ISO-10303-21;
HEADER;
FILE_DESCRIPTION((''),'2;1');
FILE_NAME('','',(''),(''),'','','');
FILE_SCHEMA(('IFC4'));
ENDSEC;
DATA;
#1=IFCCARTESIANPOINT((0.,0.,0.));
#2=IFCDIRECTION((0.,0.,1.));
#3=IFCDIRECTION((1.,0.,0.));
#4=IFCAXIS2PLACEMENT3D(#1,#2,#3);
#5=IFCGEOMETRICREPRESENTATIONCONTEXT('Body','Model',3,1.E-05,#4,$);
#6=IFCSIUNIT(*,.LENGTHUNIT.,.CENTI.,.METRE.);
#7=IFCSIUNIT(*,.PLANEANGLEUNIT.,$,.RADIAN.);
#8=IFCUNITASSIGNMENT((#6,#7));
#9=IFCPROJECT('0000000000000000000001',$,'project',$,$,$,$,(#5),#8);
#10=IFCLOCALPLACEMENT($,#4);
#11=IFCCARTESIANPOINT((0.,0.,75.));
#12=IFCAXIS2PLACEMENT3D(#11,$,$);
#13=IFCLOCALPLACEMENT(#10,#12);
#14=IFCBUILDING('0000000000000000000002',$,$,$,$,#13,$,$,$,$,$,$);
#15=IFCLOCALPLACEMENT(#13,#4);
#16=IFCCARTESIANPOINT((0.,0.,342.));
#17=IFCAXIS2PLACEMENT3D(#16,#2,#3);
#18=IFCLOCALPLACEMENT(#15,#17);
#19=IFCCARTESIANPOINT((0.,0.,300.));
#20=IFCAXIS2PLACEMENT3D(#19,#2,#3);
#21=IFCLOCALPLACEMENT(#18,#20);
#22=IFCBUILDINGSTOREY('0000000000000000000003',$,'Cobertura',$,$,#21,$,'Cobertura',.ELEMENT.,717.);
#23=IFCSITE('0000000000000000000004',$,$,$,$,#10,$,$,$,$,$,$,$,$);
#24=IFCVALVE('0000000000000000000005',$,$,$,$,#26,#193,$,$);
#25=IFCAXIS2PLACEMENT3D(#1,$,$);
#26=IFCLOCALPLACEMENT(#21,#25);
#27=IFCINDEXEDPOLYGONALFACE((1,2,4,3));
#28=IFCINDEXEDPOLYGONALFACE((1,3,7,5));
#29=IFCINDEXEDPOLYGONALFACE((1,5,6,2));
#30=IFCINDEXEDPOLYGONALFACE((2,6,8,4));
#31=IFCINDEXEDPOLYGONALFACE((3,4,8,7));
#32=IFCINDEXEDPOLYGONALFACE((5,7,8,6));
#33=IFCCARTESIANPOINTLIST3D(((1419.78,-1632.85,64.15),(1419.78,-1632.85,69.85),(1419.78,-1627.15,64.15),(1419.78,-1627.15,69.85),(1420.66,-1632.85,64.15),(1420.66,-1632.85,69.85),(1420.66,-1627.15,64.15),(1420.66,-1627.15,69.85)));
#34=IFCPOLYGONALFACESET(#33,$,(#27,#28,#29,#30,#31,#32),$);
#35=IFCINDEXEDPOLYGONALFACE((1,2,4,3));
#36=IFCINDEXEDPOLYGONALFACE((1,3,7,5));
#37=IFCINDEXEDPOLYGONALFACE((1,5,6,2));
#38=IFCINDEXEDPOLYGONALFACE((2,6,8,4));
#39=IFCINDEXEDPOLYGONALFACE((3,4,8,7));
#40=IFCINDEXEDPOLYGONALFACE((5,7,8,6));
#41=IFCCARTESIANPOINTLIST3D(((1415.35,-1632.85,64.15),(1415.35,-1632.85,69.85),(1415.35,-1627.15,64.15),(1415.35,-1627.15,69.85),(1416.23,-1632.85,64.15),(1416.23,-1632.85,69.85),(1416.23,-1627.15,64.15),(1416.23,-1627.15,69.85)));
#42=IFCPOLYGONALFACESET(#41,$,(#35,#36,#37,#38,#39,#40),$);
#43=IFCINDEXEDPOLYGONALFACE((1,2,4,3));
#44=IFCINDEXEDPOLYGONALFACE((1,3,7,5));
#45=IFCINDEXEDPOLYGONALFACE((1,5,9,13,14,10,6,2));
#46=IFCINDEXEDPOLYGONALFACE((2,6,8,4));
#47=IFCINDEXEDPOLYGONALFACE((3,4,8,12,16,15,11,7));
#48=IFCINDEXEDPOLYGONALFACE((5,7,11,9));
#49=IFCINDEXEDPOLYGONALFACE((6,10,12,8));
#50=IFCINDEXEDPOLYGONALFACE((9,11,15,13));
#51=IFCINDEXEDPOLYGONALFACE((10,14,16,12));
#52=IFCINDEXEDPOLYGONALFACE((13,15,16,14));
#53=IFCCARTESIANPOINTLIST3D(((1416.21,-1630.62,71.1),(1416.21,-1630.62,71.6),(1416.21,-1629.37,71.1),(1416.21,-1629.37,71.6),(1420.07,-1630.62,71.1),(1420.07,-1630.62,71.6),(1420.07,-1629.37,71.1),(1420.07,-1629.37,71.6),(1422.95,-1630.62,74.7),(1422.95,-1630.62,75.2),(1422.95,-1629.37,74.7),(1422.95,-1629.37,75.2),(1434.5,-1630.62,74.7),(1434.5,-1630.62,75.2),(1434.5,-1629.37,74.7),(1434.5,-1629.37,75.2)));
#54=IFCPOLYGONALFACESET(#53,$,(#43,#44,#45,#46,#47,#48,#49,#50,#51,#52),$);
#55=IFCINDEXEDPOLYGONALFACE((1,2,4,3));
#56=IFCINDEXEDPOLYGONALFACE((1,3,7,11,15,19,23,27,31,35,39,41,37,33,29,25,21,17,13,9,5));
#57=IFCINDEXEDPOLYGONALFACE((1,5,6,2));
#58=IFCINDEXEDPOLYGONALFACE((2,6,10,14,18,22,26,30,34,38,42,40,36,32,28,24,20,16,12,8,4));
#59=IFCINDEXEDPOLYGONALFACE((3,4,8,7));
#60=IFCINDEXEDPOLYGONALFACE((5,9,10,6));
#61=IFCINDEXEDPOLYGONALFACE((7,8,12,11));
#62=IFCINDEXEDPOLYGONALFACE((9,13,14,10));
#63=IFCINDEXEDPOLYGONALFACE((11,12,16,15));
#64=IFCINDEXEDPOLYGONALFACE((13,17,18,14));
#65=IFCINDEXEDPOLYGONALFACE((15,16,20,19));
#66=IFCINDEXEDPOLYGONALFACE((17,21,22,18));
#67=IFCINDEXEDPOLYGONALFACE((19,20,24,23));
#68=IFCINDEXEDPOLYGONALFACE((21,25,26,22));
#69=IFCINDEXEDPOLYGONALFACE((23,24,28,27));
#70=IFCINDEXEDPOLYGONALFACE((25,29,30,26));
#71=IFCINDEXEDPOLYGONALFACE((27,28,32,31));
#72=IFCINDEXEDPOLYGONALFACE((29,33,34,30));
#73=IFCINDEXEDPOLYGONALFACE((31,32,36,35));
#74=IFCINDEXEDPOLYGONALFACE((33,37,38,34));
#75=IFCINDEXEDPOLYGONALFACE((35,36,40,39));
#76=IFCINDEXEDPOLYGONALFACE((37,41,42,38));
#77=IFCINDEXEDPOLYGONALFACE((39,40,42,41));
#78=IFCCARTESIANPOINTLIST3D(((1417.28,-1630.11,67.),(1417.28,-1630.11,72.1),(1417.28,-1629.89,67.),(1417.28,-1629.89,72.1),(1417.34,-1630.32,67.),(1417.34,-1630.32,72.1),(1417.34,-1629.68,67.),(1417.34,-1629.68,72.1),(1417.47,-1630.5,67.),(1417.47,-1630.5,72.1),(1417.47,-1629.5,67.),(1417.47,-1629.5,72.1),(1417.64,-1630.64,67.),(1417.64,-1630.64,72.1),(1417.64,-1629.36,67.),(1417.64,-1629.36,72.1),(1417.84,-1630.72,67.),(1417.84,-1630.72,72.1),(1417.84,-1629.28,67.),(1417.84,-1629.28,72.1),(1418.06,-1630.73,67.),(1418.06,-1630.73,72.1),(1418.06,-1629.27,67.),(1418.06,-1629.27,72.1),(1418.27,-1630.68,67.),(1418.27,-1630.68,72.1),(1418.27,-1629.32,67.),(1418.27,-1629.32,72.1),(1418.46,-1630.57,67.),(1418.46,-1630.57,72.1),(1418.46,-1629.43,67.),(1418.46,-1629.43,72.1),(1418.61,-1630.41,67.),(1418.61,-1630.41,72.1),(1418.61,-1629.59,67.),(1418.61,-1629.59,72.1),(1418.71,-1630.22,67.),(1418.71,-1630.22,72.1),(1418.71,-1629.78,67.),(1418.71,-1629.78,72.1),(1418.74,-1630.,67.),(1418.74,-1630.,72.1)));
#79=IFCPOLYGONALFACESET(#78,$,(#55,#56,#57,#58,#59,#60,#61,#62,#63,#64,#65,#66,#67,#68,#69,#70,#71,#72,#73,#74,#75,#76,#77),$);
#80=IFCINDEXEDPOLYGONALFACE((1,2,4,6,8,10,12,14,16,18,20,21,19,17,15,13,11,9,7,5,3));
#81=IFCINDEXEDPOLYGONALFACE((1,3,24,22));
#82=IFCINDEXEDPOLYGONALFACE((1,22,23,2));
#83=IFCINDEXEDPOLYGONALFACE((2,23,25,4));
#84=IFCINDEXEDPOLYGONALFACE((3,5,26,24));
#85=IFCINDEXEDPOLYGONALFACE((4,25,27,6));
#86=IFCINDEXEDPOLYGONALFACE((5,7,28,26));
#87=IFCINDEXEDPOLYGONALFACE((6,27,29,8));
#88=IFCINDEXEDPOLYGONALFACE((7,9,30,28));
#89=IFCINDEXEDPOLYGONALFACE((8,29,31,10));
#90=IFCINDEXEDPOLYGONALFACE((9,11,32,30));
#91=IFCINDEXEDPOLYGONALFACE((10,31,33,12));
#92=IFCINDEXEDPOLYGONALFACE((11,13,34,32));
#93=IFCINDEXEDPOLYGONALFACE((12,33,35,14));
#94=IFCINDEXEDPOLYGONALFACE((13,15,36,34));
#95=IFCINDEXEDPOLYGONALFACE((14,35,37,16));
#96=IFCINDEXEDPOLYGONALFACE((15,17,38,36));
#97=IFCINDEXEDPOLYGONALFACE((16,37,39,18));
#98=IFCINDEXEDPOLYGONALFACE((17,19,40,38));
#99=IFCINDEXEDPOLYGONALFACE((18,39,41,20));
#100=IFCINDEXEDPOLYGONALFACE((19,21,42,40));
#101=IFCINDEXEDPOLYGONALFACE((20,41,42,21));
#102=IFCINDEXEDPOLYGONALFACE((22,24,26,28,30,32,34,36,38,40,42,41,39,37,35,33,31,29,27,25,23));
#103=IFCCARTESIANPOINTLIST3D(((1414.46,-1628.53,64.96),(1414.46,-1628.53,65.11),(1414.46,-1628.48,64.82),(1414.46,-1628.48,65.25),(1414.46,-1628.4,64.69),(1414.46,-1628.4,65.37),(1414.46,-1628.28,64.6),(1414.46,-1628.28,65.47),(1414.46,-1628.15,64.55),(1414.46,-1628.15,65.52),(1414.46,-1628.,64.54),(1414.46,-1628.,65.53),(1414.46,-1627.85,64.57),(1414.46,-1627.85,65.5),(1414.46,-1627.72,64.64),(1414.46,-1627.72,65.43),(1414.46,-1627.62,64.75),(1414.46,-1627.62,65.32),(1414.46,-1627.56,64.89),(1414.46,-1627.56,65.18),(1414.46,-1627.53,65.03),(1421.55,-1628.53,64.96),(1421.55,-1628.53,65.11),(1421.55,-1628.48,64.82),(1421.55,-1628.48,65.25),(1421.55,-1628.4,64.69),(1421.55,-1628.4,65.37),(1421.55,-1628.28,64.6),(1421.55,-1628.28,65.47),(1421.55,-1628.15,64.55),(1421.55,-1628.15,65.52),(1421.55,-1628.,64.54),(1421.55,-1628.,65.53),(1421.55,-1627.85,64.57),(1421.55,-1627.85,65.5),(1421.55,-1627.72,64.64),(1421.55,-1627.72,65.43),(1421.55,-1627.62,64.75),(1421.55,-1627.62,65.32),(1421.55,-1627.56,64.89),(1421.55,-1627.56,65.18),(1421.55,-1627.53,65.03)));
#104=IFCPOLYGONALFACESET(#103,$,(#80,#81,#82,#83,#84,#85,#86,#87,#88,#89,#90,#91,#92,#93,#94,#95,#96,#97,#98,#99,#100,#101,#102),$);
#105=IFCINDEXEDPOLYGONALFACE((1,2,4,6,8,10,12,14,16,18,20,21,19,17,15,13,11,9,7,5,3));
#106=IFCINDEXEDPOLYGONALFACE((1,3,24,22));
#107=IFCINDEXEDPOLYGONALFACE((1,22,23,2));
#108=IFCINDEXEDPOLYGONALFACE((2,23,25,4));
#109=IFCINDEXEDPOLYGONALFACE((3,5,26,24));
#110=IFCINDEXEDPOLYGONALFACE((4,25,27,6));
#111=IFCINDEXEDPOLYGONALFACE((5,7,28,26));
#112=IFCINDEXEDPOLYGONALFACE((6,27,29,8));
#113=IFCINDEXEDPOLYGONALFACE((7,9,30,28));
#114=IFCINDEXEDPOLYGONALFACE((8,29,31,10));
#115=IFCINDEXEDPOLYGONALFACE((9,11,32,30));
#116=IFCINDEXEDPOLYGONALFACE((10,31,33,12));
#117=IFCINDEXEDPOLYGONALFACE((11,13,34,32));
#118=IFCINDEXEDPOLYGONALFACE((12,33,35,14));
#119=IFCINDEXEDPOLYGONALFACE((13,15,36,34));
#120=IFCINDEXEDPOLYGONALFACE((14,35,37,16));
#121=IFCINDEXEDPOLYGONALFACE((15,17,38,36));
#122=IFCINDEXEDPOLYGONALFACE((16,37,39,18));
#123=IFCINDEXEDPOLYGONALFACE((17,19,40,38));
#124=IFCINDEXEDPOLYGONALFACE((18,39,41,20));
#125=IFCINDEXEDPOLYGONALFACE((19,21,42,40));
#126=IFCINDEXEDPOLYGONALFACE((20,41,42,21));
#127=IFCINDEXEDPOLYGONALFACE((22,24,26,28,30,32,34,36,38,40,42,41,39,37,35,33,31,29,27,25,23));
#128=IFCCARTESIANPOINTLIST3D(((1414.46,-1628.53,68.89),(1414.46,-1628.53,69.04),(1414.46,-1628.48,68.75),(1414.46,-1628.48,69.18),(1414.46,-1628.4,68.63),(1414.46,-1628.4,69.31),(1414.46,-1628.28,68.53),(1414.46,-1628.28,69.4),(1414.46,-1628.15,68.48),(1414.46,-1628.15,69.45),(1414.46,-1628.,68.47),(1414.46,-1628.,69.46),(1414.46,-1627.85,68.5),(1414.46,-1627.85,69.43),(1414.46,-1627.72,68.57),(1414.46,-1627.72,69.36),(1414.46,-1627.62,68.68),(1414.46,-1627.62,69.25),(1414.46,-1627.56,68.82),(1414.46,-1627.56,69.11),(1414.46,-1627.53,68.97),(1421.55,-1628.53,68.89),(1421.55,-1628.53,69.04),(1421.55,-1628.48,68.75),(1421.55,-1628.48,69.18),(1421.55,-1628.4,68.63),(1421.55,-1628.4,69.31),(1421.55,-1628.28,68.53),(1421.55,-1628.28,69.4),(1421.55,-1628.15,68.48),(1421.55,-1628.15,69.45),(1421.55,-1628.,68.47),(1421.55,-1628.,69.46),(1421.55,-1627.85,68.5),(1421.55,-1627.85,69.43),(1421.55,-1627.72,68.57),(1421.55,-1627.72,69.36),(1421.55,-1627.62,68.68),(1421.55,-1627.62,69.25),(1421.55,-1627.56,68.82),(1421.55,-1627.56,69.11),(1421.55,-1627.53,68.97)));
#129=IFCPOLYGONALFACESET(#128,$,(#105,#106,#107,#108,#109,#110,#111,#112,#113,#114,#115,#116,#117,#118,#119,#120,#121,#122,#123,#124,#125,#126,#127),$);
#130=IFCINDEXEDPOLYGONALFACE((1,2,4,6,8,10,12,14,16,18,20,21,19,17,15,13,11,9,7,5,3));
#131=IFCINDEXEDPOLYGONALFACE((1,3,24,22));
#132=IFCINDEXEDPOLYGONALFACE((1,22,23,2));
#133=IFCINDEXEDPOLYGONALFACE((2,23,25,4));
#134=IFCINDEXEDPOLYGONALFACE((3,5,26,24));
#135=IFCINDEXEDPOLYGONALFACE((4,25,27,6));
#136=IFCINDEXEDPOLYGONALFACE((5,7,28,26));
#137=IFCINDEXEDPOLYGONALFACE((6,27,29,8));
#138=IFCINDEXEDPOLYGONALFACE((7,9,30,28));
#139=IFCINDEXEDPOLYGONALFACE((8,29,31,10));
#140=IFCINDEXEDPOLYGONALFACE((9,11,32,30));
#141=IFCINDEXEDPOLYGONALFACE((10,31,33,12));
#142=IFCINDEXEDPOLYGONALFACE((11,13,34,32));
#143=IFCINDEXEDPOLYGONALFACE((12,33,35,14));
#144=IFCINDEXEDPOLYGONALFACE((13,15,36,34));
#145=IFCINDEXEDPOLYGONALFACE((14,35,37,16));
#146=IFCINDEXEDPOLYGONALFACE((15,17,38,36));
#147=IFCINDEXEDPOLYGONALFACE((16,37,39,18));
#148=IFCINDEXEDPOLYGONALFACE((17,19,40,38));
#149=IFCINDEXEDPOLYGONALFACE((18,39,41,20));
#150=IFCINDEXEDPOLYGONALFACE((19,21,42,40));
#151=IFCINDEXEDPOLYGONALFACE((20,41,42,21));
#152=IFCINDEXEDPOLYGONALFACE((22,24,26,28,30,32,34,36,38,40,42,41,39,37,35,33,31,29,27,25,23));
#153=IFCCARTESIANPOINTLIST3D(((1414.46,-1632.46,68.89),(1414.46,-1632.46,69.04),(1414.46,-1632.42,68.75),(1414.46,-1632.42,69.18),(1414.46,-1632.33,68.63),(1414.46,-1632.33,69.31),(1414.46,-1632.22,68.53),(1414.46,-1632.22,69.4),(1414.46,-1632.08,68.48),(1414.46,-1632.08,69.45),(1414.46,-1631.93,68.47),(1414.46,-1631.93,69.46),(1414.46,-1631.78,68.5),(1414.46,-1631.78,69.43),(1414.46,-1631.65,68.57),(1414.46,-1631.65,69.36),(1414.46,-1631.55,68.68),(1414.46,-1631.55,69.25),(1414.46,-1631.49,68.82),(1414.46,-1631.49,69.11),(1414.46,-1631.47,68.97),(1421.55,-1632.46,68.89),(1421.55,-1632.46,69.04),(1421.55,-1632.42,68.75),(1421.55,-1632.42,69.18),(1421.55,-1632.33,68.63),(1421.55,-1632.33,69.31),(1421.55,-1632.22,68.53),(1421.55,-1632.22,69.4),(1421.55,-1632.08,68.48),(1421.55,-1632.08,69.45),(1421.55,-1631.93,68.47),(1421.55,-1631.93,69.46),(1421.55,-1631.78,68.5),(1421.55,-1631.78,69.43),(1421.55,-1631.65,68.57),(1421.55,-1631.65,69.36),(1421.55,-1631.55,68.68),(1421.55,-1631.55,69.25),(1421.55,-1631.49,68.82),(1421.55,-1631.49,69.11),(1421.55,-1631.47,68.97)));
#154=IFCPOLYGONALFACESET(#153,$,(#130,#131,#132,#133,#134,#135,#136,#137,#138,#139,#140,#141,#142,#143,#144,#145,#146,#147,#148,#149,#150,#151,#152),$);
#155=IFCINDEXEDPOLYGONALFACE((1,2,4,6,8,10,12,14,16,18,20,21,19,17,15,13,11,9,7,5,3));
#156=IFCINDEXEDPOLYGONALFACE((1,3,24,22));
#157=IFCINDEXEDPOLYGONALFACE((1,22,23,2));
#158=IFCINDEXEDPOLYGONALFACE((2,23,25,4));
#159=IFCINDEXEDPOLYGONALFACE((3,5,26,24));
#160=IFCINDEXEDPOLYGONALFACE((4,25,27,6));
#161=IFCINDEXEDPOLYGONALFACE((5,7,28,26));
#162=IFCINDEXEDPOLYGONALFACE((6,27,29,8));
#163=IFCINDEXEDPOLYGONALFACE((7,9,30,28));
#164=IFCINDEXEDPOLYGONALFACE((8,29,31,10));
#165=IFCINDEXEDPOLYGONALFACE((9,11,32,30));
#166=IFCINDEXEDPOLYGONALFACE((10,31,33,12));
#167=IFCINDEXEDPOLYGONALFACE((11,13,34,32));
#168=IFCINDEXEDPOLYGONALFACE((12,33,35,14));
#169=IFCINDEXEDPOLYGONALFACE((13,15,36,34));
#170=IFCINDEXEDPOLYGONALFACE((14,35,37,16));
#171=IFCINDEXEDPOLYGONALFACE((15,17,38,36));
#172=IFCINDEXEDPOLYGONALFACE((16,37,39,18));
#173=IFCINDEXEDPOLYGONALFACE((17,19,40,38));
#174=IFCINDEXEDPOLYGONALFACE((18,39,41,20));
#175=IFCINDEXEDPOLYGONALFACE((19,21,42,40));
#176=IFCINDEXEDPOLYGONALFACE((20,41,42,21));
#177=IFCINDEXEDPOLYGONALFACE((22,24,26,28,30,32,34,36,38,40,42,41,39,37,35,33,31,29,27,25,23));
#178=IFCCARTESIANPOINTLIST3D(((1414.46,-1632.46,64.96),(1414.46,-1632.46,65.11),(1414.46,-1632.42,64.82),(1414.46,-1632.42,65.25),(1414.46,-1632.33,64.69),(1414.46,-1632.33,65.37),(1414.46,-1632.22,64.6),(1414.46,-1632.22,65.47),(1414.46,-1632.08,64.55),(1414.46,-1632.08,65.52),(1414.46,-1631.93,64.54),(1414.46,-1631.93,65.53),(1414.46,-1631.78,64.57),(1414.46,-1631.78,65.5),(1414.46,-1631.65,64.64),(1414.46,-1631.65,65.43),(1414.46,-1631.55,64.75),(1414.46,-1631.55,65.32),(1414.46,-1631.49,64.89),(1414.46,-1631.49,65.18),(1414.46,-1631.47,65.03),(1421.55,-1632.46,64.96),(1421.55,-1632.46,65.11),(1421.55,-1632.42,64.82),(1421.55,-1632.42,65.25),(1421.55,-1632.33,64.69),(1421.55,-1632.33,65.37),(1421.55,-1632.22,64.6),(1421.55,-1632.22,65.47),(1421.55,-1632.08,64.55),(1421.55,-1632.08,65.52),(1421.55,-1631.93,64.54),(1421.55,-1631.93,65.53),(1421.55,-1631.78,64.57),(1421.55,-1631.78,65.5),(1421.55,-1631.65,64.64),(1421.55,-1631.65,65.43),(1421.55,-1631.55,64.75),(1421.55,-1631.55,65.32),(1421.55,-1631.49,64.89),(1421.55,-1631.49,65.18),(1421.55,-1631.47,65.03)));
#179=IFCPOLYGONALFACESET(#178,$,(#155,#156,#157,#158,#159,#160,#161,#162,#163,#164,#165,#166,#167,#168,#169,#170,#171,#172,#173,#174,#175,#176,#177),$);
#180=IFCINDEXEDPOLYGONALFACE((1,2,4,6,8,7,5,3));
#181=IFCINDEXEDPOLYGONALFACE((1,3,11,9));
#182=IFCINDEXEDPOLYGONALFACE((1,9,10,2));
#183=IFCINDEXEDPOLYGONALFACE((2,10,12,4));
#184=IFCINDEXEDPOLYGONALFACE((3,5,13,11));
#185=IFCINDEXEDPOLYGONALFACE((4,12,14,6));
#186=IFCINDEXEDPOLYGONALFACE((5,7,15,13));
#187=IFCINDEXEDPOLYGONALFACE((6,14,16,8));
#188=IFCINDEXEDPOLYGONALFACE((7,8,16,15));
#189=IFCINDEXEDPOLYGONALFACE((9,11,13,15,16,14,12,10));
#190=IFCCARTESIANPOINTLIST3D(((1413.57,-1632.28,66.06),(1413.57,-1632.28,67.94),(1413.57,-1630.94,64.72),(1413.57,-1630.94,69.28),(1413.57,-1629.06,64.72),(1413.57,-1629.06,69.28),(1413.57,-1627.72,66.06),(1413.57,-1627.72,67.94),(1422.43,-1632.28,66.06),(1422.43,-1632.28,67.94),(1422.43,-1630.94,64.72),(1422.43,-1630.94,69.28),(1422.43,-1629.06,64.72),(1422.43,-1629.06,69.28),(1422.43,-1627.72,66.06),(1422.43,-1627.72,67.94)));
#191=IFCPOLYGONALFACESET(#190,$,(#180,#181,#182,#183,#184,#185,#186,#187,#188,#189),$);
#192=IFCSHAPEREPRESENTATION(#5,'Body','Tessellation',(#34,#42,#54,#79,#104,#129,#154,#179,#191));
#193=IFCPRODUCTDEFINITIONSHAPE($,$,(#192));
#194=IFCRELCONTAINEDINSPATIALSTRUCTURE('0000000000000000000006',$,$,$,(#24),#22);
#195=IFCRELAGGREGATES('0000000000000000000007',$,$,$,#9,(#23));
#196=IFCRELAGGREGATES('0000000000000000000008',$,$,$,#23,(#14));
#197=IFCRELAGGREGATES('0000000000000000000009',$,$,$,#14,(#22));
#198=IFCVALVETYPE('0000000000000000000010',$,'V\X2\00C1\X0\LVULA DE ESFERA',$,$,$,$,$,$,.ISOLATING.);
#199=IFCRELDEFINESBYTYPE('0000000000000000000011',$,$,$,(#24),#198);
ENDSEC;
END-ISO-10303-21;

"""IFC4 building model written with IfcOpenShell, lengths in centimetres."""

from ifc_helpers import new_model, si_unit, frame, origin_with_axes, origin_2d_with_axis, place, context, project, spatial, polyline, rectangle, circle, outline, extrude, source, transform, mapped, type_object, element, save


model = new_model("IFC4")

# Units and contexts
model_context = context("Model", 3, precision=1e-05, world=origin_with_axes(), identifier="Body")
ifc_project = project(units=[si_unit("LENGTHUNIT", "METRE", prefix="CENTI"), si_unit("PLANEANGLEUNIT", "RADIAN")], contexts=[model_context])

# Site, building, storey
site_placement = place(None, origin_with_axes())
site = spatial("IfcSite", under=ifc_project, at=site_placement)
building_placement = place(site_placement, frame((0.0, 0.0, 75.0)))
building = spatial("IfcBuilding", under=site, at=building_placement)
placement_1 = place(building_placement, origin_with_axes())
placement_2 = place(placement_1, frame((0.0, 0.0, 342.0), z_axis=(0.0, 0.0, 1.0), x_axis=(1.0, 0.0, 0.0)))
storey_placement = place(placement_2, frame((0.0, 0.0, 300.0), z_axis=(0.0, 0.0, 1.0), x_axis=(1.0, 0.0, 0.0)))
storey = spatial("IfcBuildingStorey", under=building, at=storey_placement, Name="Cobertura", LongName="Cobertura", CompositionType="ELEMENT", Elevation=717.0)

# Valve
valve_type_1 = type_object("IfcValveType", Name="VÁLVULA DE ESFERA", PredefinedType="ISOLATING")
shared_shape_1 = source(origin_with_axes(), model_context, "Body", "SolidModel", [
    extrude(rectangle(XDim=0.89, YDim=5.7, at=origin_2d_with_axis()), frame((2.21, 0.0, -2.85), z_axis=(0.0, 0.0, 1.0), x_axis=(-1.0, 0.0, 0.0)), (0.0, 0.0, 1.0), 5.7),
    extrude(rectangle(XDim=0.89, YDim=5.7, at=origin_2d_with_axis()), frame((-2.21, 0.0, -2.85), z_axis=(0.0, 0.0, 1.0), x_axis=(-1.0, 0.0, 0.0)), (0.0, 0.0, 1.0), 5.7),
    extrude(outline(polyline([(3.37, -2.05), (7.23, -2.05), (7.23, -1.55), (3.37, -1.55), (0.48, 2.05), (-11.07, 2.05), (-11.07, 1.55), (0.48, 1.55), (3.37, -2.05)])), frame((5.43, -0.62, 6.15), z_axis=(0.0, 1.0, 0.0), x_axis=(-1.0, 0.0, 0.0)), (0.0, 0.0, 1.0), 1.25),
    extrude(circle(Radius=0.73, at=origin_2d_with_axis()), origin_with_axes(), (0.0, 0.0, 1.0), 5.1),
    extrude(circle(Radius=0.5, at=origin_2d_with_axis()), frame((-3.54, 1.97, -1.97), z_axis=(1.0, 0.0, 0.0), x_axis=(0.0, 1.0, 0.0)), (0.0, 0.0, 1.0), 7.09),
    extrude(circle(Radius=0.5, at=origin_2d_with_axis()), frame((-3.54, 1.97, 1.97), z_axis=(1.0, 0.0, 0.0), x_axis=(0.0, 1.0, 0.0)), (0.0, 0.0, 1.0), 7.09),
    extrude(circle(Radius=0.5, at=origin_2d_with_axis()), frame((-3.54, -1.97, 1.97), z_axis=(1.0, 0.0, 0.0), x_axis=(0.0, 1.0, 0.0)), (0.0, 0.0, 1.0), 7.09),
    extrude(circle(Radius=0.5, at=origin_2d_with_axis()), frame((-3.54, -1.97, -1.97), z_axis=(1.0, 0.0, 0.0), x_axis=(0.0, 1.0, 0.0)), (0.0, 0.0, 1.0), 7.09),
    extrude(outline(polyline([(-0.94, -2.28), (0.94, -2.28), (2.28, -0.94), (2.28, 0.94), (0.94, 2.28), (-0.94, 2.28), (-2.28, 0.94), (-2.28, -0.94), (-0.94, -2.28)])), frame((-4.43, 0.0, 0.0), z_axis=(1.0, 0.0, 0.0), x_axis=(0.0, -0.707107, -0.707107)), (0.0, 0.0, 1.0), 8.86),
])
valve_1_placement = place(storey_placement, frame((1418.0, -1630.0, 67.0), z_axis=(0.0, 0.0, 1.0), x_axis=(1.0, 0.0, 0.0)))
element("IfcValve", 1, at=valve_1_placement, inside=storey, type_object=valve_type_1, context=model_context, shape_type="MappedRepresentation", body=[
    mapped(shared_shape_1, transform((0.0, 0.0, 0.0), scale=1.0)),
])

save(model, "model.ifc")
